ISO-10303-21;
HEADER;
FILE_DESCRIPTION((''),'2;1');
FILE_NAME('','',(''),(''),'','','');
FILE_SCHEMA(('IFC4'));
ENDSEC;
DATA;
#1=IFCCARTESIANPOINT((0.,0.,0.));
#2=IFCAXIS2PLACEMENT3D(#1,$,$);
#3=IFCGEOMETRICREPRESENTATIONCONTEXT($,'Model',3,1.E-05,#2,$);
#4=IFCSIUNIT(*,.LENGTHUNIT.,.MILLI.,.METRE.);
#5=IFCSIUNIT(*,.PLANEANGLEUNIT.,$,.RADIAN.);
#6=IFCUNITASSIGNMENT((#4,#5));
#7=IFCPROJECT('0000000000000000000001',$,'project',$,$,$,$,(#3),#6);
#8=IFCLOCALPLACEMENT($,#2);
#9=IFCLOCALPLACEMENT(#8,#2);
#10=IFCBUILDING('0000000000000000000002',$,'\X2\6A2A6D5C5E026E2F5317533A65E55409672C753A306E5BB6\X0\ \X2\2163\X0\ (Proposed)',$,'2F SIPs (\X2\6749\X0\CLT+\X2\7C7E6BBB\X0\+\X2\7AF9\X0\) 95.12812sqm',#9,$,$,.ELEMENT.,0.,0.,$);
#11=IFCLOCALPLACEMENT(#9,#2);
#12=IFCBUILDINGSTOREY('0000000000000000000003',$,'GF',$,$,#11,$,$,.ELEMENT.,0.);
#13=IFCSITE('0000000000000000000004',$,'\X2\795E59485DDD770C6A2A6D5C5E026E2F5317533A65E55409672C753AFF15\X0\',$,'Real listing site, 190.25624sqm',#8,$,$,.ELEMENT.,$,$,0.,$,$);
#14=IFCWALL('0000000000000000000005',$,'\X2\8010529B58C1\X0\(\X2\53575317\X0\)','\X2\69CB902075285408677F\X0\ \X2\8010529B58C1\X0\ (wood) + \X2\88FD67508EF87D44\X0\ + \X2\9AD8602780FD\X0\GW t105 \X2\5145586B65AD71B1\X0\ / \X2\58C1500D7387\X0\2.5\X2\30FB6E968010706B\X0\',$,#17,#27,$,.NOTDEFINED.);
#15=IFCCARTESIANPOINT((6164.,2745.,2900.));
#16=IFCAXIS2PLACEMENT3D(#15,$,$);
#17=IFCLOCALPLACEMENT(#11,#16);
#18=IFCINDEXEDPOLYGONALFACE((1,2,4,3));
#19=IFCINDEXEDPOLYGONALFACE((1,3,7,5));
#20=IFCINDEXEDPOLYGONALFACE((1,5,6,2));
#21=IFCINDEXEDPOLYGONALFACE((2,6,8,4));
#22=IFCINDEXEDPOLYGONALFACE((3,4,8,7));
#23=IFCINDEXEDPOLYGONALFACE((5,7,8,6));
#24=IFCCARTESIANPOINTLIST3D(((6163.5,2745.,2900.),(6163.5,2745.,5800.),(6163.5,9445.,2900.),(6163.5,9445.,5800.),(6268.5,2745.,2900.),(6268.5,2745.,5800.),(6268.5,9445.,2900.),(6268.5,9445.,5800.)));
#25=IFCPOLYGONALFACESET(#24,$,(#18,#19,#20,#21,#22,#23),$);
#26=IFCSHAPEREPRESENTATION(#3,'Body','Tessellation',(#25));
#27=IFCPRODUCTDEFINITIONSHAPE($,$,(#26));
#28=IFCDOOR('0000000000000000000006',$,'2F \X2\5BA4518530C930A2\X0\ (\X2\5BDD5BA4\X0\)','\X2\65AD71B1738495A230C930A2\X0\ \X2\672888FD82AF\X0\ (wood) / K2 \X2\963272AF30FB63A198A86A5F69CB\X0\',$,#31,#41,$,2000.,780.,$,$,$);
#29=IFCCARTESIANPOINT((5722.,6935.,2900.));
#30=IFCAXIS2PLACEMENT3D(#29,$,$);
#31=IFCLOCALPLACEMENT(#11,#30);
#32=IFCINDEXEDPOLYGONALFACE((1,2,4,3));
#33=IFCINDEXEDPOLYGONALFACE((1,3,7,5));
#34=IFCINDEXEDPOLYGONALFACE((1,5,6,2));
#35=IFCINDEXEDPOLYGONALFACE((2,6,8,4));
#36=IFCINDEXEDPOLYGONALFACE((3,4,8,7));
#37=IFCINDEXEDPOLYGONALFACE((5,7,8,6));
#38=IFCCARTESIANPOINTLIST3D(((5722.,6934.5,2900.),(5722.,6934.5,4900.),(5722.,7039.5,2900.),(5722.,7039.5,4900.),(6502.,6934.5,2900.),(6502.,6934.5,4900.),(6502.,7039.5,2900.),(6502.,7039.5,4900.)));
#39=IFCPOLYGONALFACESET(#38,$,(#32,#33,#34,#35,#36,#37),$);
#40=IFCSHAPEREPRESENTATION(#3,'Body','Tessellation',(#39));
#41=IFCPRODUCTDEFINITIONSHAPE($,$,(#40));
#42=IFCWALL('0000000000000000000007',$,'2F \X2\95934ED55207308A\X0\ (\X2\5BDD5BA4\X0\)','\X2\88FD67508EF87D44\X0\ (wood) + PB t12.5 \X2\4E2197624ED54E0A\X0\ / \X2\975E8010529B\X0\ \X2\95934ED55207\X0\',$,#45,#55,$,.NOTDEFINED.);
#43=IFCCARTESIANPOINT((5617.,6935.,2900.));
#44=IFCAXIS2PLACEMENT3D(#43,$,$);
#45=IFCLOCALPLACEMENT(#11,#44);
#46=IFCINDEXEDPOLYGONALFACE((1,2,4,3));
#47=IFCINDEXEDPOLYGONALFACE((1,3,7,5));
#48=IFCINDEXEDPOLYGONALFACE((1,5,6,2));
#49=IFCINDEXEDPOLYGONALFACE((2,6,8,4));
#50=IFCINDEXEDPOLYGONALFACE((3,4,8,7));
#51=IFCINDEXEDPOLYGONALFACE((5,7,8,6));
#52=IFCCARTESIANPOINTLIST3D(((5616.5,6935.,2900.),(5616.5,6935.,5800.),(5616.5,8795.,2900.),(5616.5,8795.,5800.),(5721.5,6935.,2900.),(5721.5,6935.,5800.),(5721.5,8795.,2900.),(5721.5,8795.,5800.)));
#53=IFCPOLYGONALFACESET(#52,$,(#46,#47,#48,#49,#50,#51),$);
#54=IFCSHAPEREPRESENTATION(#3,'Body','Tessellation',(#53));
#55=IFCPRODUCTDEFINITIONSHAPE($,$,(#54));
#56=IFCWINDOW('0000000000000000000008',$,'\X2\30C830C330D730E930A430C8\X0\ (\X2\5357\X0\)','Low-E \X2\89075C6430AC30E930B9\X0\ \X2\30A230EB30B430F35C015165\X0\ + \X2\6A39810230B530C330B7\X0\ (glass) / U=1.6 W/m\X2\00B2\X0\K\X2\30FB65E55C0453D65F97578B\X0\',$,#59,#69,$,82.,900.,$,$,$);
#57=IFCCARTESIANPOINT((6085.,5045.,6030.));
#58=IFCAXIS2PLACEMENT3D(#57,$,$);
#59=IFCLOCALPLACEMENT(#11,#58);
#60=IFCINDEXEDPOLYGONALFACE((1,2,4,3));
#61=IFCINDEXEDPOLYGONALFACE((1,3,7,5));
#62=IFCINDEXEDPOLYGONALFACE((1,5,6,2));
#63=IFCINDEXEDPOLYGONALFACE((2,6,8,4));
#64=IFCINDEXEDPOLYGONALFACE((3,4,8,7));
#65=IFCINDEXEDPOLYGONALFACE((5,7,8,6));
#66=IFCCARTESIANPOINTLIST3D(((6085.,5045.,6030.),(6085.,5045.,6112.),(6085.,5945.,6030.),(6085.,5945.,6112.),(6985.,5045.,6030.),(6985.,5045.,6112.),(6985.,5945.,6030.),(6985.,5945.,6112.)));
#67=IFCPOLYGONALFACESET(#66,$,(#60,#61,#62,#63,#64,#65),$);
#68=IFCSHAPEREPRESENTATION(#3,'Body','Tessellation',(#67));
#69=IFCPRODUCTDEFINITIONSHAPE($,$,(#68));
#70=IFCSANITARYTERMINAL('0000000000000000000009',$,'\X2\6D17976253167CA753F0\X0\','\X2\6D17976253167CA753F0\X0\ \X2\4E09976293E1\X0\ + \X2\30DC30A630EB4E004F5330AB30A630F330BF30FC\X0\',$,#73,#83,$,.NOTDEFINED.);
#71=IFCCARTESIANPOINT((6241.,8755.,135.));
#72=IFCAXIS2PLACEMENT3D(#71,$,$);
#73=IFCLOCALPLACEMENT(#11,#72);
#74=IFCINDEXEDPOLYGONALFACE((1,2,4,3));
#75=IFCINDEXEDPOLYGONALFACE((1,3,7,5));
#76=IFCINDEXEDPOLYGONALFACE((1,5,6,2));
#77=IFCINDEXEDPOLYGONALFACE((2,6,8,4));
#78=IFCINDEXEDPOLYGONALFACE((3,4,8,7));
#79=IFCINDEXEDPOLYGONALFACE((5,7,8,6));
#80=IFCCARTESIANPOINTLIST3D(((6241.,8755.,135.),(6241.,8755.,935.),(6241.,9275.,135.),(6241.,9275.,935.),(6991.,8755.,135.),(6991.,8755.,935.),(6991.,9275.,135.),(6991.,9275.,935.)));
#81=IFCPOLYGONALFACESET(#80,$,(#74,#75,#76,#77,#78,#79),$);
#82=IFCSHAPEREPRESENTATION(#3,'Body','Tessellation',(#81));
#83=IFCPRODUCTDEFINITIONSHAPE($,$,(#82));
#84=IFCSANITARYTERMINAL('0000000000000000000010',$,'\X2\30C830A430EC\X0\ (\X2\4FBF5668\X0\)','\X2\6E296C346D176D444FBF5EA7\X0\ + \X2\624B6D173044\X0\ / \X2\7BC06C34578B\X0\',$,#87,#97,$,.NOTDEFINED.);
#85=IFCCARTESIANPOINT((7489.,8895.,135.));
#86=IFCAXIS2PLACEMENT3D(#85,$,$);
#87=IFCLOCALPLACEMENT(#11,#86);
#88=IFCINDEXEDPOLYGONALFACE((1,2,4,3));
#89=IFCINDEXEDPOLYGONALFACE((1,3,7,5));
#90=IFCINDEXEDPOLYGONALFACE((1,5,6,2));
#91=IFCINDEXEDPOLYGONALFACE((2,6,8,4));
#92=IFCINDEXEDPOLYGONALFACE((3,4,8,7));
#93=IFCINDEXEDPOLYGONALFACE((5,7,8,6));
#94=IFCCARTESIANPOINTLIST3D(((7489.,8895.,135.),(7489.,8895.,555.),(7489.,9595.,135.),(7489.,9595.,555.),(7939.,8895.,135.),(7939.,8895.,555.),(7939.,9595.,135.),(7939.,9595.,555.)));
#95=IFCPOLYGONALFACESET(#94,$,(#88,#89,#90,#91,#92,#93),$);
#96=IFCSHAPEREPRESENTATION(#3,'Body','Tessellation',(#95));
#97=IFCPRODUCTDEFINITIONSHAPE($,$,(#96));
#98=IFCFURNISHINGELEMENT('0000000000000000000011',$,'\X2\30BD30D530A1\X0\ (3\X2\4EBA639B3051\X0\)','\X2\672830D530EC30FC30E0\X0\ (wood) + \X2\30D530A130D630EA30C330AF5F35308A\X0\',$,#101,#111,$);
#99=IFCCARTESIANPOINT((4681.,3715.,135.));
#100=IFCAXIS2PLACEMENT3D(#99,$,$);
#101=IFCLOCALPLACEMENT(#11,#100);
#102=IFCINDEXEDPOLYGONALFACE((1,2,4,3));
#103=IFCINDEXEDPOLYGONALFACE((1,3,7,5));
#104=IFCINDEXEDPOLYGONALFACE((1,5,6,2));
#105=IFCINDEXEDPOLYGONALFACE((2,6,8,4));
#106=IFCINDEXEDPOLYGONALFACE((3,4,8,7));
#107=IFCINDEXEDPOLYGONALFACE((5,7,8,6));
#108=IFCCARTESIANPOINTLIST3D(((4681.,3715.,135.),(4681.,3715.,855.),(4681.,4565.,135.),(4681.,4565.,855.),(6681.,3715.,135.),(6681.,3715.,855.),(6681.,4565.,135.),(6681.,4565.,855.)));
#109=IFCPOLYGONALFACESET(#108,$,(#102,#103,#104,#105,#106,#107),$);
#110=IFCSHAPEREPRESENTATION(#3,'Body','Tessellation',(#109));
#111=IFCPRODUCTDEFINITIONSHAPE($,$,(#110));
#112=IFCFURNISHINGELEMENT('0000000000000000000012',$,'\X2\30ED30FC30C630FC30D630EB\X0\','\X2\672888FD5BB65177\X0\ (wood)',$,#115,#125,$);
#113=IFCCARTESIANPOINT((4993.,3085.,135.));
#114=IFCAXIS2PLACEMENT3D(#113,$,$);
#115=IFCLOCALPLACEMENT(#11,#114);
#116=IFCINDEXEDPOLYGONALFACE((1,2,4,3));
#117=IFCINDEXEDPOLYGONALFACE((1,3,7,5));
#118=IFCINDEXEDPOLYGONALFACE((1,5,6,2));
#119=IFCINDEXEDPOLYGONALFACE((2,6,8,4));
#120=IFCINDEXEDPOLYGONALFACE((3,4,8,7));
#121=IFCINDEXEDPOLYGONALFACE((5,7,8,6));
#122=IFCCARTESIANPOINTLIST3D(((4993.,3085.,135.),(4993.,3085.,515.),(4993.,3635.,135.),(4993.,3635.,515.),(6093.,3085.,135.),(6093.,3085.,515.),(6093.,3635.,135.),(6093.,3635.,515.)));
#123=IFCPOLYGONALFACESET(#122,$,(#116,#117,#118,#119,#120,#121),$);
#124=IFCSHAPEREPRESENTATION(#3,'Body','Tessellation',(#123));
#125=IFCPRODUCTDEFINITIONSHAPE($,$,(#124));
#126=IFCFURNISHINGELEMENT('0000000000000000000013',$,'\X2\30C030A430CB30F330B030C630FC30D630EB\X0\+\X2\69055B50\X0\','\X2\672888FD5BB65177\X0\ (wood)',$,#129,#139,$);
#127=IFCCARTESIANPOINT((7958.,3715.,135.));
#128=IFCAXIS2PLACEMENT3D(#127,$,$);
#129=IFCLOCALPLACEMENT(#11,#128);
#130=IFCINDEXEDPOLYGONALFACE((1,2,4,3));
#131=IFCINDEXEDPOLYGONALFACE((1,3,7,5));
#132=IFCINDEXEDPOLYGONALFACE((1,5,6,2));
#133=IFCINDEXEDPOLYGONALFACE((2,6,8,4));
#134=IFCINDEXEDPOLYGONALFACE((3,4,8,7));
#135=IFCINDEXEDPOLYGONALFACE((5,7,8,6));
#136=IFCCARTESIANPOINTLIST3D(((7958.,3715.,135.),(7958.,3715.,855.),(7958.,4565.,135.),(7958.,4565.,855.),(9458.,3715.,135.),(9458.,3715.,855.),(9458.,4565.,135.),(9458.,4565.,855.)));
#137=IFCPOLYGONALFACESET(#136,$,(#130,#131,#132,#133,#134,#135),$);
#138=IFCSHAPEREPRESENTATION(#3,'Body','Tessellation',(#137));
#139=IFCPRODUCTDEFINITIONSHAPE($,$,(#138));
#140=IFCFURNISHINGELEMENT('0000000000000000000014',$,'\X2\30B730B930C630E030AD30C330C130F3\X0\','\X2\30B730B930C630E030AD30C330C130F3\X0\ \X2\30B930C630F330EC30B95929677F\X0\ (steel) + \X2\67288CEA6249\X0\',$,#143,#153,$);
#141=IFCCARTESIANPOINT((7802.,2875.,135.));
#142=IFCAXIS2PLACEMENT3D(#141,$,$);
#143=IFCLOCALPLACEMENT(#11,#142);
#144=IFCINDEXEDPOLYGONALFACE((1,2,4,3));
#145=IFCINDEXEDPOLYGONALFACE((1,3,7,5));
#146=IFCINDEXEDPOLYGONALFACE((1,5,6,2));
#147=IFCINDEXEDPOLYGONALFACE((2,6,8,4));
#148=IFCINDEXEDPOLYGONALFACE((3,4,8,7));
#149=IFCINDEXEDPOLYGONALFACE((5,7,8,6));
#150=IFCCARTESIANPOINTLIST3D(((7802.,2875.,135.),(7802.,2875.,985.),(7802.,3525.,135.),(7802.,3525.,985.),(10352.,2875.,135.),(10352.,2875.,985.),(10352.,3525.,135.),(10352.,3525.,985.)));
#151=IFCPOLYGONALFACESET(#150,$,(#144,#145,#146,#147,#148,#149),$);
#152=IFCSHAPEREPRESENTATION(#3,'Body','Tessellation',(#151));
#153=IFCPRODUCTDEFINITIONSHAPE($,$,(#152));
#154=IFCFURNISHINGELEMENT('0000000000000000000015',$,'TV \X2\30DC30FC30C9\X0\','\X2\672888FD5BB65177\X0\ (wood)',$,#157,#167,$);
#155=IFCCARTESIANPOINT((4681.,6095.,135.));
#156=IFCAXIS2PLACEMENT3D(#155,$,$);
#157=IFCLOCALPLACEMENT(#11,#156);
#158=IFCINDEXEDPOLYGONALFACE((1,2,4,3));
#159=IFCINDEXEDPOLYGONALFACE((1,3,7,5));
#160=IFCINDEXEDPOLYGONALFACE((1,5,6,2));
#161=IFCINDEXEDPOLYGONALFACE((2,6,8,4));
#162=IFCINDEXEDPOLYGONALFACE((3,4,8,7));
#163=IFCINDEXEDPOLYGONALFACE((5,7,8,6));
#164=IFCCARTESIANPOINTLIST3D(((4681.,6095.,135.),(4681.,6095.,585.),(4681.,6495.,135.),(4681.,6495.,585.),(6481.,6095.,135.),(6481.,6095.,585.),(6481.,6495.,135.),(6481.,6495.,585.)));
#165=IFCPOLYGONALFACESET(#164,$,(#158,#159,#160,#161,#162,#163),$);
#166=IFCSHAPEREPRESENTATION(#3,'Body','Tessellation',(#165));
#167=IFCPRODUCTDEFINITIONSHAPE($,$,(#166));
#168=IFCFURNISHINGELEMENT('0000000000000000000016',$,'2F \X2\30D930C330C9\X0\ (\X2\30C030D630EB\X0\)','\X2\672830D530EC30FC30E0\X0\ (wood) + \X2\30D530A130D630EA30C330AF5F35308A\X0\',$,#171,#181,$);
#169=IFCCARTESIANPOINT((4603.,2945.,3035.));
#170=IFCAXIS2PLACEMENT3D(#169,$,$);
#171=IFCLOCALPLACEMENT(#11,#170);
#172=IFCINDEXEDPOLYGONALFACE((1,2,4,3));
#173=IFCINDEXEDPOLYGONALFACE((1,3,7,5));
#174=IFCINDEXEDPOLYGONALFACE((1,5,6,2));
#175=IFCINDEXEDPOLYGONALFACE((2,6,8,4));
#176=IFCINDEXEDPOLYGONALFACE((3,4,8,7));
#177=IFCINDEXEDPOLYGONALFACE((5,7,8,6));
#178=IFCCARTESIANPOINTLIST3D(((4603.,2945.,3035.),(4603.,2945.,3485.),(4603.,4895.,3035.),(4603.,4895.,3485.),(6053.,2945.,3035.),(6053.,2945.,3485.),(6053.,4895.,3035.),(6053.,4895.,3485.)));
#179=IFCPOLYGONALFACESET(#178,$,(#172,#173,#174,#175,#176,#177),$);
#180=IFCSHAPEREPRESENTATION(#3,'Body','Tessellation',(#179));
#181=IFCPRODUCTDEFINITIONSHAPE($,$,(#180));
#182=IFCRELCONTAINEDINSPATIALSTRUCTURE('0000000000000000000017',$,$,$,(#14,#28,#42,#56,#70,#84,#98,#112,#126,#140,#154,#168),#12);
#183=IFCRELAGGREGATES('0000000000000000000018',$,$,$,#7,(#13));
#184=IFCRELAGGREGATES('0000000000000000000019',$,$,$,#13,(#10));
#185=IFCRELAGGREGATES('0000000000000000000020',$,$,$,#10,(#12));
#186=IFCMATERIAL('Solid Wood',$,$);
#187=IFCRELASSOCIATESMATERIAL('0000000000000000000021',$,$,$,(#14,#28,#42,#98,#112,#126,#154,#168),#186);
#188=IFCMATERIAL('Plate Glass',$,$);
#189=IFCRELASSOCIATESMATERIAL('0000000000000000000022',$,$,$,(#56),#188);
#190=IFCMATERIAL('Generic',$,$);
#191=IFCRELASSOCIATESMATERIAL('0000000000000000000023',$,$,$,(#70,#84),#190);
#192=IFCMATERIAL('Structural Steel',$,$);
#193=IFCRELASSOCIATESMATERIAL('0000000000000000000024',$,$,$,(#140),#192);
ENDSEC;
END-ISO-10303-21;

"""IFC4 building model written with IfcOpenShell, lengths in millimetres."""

from ifc_helpers import new_model, si_unit, frame, frame_2d, origin, place, context, project, spatial, rectangle, extrude, material, element, fill, save


model = new_model("IFC4")

# Units and contexts
model_context = context("Model", 3, precision=1e-05, world=origin())
ifc_project = project(units=[si_unit("LENGTHUNIT", "METRE", prefix="MILLI"), si_unit("PLANEANGLEUNIT", "RADIAN")], contexts=[model_context])

# Site, building, storey
site_placement = place(None, origin())
site = spatial("IfcSite", under=ifc_project, at=site_placement, Name="神奈川県横浜市港北区日吉本町５", ObjectType="Real listing site, 190.25624sqm", CompositionType="ELEMENT", RefElevation=0.0)
building_placement = place(site_placement, origin())
building = spatial("IfcBuilding", under=site, at=building_placement, Name="横浜市港北区日吉本町の家 Ⅳ (Proposed)", ObjectType="2F SIPs (杉CLT+籾殻+竹) 95.12812sqm", CompositionType="ELEMENT", ElevationOfRefHeight=0.0, ElevationOfTerrain=0.0)
storey_placement = place(building_placement, origin())
storey = spatial("IfcBuildingStorey", under=building, at=storey_placement, Name="GF", CompositionType="ELEMENT", Elevation=0.0)

# Shared definitions
ifc_material_1 = material(Name="Solid Wood")

# Wall, opening, door
wall_1_placement = place(storey_placement, frame((6164.0, 2745.0, 2900.0)))
wall_1 = element("IfcWall", 1, at=wall_1_placement, inside=storey, material=ifc_material_1, Name="耐力壁(南北)", Description="構造用合板 耐力壁 (wood) + 製材軸組 + 高性能GW t105 充填断熱 / 壁倍率2.5・準耐火", PredefinedType="NOTDEFINED", context=model_context, shape_type="SweptSolid", body=[
    extrude(rectangle(XDim=105.0, YDim=6700.0, at=frame_2d((52.0, 3350.0))), frame((6164.0, 2745.0, 2900.0)), (0.0, 0.0, 1.0), 2900.0),
])
opening_1_placement = place(storey_placement, frame((5722.0, 6935.0, 2900.0)))
opening_1 = element("IfcOpeningElement", 2, at=opening_1_placement, cuts=wall_1, PredefinedType="NOTDEFINED", context=model_context, shape_type="SweptSolid", body=[
    extrude(rectangle(XDim=780.0, YDim=105.0, at=frame_2d((390.0, 52.0))), frame((5722.0, 6935.0, 2900.0)), (0.0, 0.0, 1.0), 2000.0),
])
door_1_placement = place(storey_placement, frame((5722.0, 6935.0, 2900.0)))
door_1 = element("IfcDoor", 3, at=door_1_placement, inside=storey, material=ifc_material_1, Name="2F 室内ドア (寝室)", Description="断熱玄関ドア 木製芯 (wood) / K2 防犯・採風機構", OverallHeight=2000.0, OverallWidth=780.0, context=model_context, shape_type="SweptSolid", body=[
    extrude(rectangle(XDim=780.0, YDim=105.0, at=frame_2d((390.0, 52.0))), frame((5722.0, 6935.0, 2900.0)), (0.0, 0.0, 1.0), 2000.0),
])
fill(opening_1, door_1)

# Wall
wall_2_placement = place(storey_placement, frame((5617.0, 6935.0, 2900.0)))
element("IfcWall", 4, at=wall_2_placement, inside=storey, material=ifc_material_1, Name="2F 間仕切り (寝室)", Description="製材軸組 (wood) + PB t12.5 両面仕上 / 非耐力 間仕切", PredefinedType="NOTDEFINED", context=model_context, shape_type="SweptSolid", body=[
    extrude(rectangle(XDim=105.0, YDim=1860.0, at=frame_2d((52.0, 930.0))), frame((5617.0, 6935.0, 2900.0)), (0.0, 0.0, 1.0), 2900.0),
])

# Window
ifc_material_2 = material(Name="Plate Glass")
window_placement = place(storey_placement, frame((6085.0, 5045.0, 6030.0)))
element("IfcWindow", 5, at=window_placement, inside=storey, material=ifc_material_2, Name="トップライト (南)", Description="Low-E 複層ガラス アルゴン封入 + 樹脂サッシ (glass) / U=1.6 W/m²K・日射取得型", OverallHeight=82.0, OverallWidth=900.0, context=model_context, shape_type="SweptSolid", body=[
    extrude(rectangle(XDim=900.0, YDim=900.0, at=frame_2d((450.0, 450.0))), frame((6085.0, 5045.0, 6030.0)), (0.0, 0.0, 1.0), 82.0),
])

# Sanitary terminals
ifc_material_3 = material(Name="Generic")
sanitary_terminal_1_placement = place(storey_placement, frame((6241.0, 8755.0, 135.0)))
element("IfcSanitaryTerminal", 6, at=sanitary_terminal_1_placement, inside=storey, material=ifc_material_3, Name="洗面化粧台", Description="洗面化粧台 三面鏡 + ボウル一体カウンター", PredefinedType="NOTDEFINED", context=model_context, shape_type="SweptSolid", body=[
    extrude(rectangle(XDim=750.0, YDim=520.0, at=frame_2d((375.0, 260.0))), frame((6241.0, 8755.0, 135.0)), (0.0, 0.0, 1.0), 800.0),
])
sanitary_terminal_2_placement = place(storey_placement, frame((7489.0, 8895.0, 135.0)))
element("IfcSanitaryTerminal", 7, at=sanitary_terminal_2_placement, inside=storey, material=ifc_material_3, Name="トイレ (便器)", Description="温水洗浄便座 + 手洗い / 節水型", PredefinedType="NOTDEFINED", context=model_context, shape_type="SweptSolid", body=[
    extrude(rectangle(XDim=450.0, YDim=700.0, at=frame_2d((225.0, 350.0))), frame((7489.0, 8895.0, 135.0)), (0.0, 0.0, 1.0), 420.0),
])

# Furnishing elements
furnishing_1_placement = place(storey_placement, frame((4681.0, 3715.0, 135.0)))
element("IfcFurnishingElement", 8, at=furnishing_1_placement, inside=storey, material=ifc_material_1, Name="ソファ (3人掛け)", Description="木フレーム (wood) + ファブリック張り", context=model_context, shape_type="SweptSolid", body=[
    extrude(rectangle(XDim=2000.0, YDim=850.0, at=frame_2d((1000.0, 425.0))), frame((4681.0, 3715.0, 135.0)), (0.0, 0.0, 1.0), 720.0),
])
furnishing_2_placement = place(storey_placement, frame((4993.0, 3085.0, 135.0)))
element("IfcFurnishingElement", 9, at=furnishing_2_placement, inside=storey, material=ifc_material_1, Name="ローテーブル", Description="木製家具 (wood)", context=model_context, shape_type="SweptSolid", body=[
    extrude(rectangle(XDim=1100.0, YDim=550.0, at=frame_2d((550.0, 275.0))), frame((4993.0, 3085.0, 135.0)), (0.0, 0.0, 1.0), 380.0),
])
furnishing_3_placement = place(storey_placement, frame((7958.0, 3715.0, 135.0)))
element("IfcFurnishingElement", 10, at=furnishing_3_placement, inside=storey, material=ifc_material_1, Name="ダイニングテーブル+椅子", Description="木製家具 (wood)", context=model_context, shape_type="SweptSolid", body=[
    extrude(rectangle(XDim=1500.0, YDim=850.0, at=frame_2d((750.0, 425.0))), frame((7958.0, 3715.0, 135.0)), (0.0, 0.0, 1.0), 720.0),
])
ifc_material_4 = material(Name="Structural Steel")
furnishing_4_placement = place(storey_placement, frame((7802.0, 2875.0, 135.0)))
element("IfcFurnishingElement", 11, at=furnishing_4_placement, inside=storey, material=ifc_material_4, Name="システムキッチン", Description="システムキッチン ステンレス天板 (steel) + 木質扉", context=model_context, shape_type="SweptSolid", body=[
    extrude(rectangle(XDim=2550.0, YDim=650.0, at=frame_2d((1275.0, 325.0))), frame((7802.0, 2875.0, 135.0)), (0.0, 0.0, 1.0), 850.0),
])
furnishing_5_placement = place(storey_placement, frame((4681.0, 6095.0, 135.0)))
element("IfcFurnishingElement", 12, at=furnishing_5_placement, inside=storey, material=ifc_material_1, Name="TV ボード", Description="木製家具 (wood)", context=model_context, shape_type="SweptSolid", body=[
    extrude(rectangle(XDim=1800.0, YDim=400.0, at=frame_2d((900.0, 200.0))), frame((4681.0, 6095.0, 135.0)), (0.0, 0.0, 1.0), 450.0),
])
furnishing_6_placement = place(storey_placement, frame((4603.0, 2945.0, 3035.0)))
element("IfcFurnishingElement", 13, at=furnishing_6_placement, inside=storey, material=ifc_material_1, Name="2F ベッド (ダブル)", Description="木フレーム (wood) + ファブリック張り", context=model_context, shape_type="SweptSolid", body=[
    extrude(rectangle(XDim=1450.0, YDim=1950.0, at=frame_2d((725.0, 975.0))), frame((4603.0, 2945.0, 3035.0)), (0.0, 0.0, 1.0), 450.0),
])

save(model, "model.ifc")
